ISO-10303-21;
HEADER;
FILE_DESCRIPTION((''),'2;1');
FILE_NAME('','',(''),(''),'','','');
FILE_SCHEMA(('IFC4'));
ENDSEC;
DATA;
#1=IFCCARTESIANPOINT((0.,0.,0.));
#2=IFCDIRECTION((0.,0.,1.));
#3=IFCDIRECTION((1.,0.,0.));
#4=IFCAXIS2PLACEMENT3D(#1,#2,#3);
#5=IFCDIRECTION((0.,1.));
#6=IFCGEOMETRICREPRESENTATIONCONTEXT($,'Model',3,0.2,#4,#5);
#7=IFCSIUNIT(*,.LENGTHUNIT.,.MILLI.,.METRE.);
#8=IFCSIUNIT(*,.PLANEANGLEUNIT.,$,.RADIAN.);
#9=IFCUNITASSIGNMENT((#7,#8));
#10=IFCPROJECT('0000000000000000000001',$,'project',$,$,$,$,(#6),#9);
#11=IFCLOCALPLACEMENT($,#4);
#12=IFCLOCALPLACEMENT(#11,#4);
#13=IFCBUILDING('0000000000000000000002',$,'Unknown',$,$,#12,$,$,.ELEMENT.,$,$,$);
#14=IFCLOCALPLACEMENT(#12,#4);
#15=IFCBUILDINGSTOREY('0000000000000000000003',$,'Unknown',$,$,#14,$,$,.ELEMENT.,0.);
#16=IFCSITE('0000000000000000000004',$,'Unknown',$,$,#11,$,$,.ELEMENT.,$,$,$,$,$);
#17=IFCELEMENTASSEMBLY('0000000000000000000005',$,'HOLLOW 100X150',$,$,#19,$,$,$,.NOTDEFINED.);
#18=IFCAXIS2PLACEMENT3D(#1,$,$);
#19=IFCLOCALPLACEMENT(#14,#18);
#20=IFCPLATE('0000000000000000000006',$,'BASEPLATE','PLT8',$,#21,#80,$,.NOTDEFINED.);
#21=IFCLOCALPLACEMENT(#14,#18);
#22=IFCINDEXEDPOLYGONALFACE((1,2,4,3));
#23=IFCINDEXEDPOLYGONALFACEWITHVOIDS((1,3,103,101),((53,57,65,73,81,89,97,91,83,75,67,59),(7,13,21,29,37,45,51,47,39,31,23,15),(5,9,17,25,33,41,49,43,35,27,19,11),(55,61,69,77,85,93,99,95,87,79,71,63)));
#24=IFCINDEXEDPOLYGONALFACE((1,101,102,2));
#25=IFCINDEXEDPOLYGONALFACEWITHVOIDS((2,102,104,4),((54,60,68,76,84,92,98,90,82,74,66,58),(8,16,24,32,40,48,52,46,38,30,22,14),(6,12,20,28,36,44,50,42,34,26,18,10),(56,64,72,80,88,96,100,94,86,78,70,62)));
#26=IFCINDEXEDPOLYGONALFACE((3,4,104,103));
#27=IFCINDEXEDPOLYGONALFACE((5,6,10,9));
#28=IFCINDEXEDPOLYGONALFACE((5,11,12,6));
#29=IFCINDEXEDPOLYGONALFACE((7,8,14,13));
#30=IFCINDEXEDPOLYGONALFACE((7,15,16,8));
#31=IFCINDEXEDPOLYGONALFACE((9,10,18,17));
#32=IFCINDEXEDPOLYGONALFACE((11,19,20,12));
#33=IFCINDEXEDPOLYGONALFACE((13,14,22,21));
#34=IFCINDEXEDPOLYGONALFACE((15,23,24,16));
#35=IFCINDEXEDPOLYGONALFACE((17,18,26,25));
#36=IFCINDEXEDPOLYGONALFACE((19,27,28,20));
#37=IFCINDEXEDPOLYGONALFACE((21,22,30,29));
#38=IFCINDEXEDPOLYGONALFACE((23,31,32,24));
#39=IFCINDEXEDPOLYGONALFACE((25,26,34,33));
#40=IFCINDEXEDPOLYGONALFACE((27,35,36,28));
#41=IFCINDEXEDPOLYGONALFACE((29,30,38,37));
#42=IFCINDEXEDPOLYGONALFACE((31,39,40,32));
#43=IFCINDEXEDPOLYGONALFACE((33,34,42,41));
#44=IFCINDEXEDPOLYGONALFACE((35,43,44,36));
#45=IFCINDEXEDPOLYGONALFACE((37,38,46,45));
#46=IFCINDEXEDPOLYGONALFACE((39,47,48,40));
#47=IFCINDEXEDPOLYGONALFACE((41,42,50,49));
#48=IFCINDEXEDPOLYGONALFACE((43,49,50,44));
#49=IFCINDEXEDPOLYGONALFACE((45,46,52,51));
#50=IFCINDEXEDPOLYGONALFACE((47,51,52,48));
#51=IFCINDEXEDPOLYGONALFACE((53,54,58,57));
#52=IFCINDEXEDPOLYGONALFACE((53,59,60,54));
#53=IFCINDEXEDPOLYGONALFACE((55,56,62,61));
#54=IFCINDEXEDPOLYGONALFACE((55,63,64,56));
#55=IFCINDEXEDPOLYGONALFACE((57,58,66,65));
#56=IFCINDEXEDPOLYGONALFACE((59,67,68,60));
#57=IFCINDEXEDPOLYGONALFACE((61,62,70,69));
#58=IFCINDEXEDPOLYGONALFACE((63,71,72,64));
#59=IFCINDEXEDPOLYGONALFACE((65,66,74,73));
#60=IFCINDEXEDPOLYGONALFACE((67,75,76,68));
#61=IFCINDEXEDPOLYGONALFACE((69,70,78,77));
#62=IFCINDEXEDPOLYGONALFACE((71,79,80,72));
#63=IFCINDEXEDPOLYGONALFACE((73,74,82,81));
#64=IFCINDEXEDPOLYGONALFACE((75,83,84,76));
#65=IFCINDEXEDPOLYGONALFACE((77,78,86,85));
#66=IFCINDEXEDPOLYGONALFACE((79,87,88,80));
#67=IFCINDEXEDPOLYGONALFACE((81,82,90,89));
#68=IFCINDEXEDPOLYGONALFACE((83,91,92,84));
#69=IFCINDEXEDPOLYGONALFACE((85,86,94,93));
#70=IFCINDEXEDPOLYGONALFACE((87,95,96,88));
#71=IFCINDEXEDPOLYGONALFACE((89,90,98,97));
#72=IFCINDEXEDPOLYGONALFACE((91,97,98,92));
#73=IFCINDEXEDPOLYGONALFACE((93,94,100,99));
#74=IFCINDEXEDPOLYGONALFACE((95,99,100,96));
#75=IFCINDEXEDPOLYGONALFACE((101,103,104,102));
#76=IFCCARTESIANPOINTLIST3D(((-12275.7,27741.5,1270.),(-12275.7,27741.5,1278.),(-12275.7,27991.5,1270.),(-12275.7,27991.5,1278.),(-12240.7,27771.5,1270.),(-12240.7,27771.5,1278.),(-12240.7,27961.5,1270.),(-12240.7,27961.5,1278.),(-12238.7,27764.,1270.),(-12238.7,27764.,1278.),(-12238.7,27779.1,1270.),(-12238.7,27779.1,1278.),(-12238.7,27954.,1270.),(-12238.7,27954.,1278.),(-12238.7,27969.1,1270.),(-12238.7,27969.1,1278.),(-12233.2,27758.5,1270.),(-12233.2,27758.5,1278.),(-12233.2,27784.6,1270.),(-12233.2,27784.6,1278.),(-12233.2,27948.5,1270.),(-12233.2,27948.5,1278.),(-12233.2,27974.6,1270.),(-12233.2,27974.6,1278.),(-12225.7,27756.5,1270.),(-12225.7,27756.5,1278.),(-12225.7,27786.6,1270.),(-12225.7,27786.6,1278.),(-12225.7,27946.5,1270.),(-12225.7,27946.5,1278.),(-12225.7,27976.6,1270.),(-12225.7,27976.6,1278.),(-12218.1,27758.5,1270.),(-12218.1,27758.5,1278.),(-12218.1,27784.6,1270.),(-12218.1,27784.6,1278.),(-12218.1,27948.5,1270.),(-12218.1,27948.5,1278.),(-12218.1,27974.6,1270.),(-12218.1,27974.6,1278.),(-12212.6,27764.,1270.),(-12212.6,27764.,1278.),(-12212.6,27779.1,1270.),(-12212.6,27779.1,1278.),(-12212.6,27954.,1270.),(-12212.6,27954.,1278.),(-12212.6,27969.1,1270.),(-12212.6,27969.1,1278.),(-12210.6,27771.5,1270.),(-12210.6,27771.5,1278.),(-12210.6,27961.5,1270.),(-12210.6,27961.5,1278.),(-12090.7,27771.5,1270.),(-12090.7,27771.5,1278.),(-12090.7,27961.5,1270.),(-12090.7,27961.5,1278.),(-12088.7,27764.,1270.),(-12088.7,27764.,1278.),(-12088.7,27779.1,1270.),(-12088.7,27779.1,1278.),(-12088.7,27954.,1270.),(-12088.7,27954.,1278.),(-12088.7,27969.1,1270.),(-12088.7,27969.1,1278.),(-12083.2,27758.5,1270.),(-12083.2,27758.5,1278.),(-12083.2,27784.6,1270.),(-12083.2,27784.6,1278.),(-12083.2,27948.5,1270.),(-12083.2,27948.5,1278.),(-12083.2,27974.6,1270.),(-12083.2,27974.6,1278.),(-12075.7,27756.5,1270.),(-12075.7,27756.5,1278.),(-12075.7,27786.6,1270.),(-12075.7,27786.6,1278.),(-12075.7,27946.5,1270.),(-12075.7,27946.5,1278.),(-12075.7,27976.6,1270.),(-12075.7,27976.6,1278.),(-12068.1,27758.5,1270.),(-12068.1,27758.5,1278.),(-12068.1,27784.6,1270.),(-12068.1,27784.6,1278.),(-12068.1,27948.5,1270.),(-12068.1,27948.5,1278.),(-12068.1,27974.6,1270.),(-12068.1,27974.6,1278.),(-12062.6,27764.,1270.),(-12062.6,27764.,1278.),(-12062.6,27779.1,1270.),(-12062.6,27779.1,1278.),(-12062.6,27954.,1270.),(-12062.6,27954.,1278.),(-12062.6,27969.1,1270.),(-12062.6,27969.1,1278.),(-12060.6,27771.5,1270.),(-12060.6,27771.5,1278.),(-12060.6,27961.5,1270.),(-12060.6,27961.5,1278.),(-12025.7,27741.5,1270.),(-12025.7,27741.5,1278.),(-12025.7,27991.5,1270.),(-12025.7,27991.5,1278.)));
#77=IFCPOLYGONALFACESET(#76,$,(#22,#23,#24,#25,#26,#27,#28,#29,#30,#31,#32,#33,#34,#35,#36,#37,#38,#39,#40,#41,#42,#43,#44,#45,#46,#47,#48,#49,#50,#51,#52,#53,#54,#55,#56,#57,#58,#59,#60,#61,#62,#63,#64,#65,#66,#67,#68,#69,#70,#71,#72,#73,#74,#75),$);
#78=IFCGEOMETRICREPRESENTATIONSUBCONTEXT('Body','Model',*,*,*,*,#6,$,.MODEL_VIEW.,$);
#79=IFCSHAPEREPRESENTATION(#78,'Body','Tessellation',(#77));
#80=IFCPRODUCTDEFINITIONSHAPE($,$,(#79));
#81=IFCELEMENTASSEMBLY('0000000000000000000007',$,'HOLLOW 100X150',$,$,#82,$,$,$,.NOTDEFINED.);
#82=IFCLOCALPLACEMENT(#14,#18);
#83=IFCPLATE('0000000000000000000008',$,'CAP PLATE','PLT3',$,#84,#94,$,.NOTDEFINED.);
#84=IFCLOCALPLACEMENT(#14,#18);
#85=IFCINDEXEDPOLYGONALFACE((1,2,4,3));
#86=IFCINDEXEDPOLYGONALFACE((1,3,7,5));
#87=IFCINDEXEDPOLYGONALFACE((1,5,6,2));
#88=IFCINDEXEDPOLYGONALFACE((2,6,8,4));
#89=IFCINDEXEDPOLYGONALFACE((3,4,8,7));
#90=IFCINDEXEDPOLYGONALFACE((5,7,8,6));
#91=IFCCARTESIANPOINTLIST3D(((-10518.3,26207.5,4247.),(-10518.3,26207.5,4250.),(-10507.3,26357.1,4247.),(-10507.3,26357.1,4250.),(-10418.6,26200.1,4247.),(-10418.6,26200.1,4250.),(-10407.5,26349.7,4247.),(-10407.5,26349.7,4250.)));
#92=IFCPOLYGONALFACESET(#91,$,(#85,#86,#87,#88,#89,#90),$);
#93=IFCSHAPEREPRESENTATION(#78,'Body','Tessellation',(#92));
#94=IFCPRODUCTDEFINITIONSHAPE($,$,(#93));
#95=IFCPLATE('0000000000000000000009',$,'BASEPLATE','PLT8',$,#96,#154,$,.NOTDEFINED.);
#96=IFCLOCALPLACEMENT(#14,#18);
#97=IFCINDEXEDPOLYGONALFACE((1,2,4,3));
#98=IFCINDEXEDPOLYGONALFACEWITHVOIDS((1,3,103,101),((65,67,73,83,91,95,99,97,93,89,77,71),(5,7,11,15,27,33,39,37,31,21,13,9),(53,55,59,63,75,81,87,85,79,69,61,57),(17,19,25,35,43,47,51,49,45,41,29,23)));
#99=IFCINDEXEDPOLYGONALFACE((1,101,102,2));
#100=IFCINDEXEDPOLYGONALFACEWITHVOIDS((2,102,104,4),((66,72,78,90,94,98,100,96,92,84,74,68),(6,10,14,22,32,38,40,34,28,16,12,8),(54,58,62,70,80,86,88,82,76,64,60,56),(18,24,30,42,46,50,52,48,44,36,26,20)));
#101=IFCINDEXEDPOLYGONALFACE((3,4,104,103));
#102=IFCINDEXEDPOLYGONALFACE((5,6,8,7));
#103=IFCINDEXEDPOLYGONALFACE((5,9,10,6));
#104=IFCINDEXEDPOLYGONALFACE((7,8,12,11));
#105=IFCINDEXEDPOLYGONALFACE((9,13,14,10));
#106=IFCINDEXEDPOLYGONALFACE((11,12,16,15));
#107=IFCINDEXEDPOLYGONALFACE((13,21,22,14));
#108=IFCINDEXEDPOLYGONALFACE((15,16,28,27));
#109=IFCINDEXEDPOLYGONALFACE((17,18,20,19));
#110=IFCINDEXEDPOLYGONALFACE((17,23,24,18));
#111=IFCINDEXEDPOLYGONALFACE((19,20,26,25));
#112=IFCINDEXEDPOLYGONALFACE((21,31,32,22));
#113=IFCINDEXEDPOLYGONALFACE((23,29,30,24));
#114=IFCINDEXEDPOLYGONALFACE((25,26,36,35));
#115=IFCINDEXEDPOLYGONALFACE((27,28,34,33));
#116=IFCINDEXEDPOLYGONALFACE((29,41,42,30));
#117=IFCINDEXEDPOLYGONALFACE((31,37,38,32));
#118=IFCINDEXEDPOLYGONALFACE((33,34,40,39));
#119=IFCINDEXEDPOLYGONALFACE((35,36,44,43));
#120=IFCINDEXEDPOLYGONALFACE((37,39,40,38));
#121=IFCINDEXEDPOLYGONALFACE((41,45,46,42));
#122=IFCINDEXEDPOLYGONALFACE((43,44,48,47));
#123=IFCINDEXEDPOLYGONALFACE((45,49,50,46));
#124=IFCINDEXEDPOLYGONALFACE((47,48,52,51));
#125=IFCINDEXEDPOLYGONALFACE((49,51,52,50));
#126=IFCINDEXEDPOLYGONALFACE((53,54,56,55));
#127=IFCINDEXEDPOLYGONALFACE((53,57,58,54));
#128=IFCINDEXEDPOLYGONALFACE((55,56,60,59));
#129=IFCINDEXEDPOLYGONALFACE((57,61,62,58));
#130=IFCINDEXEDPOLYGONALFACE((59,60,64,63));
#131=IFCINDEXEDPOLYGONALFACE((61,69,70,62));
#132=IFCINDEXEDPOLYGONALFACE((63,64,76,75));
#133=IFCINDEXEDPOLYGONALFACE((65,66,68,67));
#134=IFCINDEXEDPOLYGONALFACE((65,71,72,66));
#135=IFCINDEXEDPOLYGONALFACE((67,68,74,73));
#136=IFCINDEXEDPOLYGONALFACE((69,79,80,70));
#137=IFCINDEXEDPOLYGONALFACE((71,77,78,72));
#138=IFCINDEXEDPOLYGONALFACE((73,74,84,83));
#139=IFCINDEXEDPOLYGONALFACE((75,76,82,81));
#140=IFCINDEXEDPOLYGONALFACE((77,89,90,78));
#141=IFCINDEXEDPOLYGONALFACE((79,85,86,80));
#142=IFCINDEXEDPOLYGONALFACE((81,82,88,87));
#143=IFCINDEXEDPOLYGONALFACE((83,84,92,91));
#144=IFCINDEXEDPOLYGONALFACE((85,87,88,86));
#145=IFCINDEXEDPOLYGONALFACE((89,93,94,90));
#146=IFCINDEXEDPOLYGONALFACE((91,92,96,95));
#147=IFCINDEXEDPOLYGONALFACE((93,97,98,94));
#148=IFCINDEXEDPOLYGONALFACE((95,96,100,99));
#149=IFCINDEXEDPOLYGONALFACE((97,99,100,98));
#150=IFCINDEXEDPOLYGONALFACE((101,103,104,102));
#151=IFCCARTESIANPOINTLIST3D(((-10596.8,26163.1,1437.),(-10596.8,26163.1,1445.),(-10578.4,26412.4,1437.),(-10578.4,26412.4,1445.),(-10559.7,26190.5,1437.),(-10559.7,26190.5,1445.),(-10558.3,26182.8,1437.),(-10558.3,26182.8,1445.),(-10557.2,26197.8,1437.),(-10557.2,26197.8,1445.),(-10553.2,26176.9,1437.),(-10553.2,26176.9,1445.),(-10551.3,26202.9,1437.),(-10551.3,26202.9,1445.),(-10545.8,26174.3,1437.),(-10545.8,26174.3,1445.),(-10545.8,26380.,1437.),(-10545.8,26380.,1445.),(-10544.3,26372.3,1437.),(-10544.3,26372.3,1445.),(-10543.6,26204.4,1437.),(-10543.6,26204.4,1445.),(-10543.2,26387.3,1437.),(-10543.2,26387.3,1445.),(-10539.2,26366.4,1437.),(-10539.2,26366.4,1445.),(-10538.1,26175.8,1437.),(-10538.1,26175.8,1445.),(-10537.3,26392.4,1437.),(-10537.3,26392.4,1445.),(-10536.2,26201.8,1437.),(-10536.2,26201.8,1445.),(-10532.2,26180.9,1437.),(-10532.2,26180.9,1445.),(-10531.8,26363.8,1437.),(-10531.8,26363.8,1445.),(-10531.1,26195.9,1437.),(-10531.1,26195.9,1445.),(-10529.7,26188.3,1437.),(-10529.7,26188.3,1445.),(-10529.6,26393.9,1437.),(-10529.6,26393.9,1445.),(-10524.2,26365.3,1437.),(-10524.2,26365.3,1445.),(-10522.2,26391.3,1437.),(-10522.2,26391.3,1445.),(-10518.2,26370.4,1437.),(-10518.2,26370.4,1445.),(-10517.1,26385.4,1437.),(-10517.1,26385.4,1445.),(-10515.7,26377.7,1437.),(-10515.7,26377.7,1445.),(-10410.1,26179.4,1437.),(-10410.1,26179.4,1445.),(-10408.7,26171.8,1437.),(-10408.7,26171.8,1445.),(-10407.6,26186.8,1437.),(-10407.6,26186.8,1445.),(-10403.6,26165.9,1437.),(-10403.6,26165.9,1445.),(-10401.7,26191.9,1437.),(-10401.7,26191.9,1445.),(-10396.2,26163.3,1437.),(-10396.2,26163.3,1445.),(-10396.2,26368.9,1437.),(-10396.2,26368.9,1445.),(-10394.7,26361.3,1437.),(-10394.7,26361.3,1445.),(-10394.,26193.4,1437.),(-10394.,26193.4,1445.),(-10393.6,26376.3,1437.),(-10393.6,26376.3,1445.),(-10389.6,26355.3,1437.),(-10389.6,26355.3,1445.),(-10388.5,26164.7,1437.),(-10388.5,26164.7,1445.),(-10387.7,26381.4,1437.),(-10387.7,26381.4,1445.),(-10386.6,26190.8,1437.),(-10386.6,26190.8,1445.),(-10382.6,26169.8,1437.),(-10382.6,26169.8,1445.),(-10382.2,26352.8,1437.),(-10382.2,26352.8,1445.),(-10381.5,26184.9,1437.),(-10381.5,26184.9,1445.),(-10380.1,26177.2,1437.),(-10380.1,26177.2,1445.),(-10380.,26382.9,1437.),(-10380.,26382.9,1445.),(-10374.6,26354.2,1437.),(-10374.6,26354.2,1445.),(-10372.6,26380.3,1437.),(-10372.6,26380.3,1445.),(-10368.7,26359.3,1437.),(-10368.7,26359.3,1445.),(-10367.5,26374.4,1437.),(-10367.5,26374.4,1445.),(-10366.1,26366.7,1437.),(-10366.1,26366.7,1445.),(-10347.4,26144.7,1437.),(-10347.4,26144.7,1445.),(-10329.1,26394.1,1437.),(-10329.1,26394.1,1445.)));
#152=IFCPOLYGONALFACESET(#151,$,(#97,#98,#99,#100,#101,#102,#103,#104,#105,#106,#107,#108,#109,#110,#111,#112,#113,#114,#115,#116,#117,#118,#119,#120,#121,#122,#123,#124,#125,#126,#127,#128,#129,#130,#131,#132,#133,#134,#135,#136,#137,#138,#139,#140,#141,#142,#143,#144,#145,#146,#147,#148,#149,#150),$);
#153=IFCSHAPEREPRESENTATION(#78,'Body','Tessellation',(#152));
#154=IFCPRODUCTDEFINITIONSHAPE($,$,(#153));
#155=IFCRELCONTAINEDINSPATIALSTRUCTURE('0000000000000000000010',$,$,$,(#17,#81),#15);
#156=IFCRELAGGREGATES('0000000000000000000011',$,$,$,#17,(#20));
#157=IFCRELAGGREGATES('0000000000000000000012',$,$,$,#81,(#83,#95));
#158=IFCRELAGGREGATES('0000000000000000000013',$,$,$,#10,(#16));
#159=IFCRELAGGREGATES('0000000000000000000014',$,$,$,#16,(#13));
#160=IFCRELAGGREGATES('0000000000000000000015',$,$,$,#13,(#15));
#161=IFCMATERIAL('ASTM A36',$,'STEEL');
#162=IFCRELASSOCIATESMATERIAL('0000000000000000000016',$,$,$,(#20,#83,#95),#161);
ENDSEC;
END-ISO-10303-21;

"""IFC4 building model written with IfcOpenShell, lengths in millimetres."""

from ifc_helpers import new_model, si_unit, direction, frame, origin_with_axes, place, context, subcontext, project, spatial, line, indexed_curve, outline, extrude, material, element, aggregate, save


model = new_model("IFC4")

# Units and contexts
model_context = context("Model", 3, precision=0.2, world=origin_with_axes(), true_north=direction((0.0, 1.0)))
body_context = subcontext(model_context, "Body", "Model", "MODEL_VIEW")
ifc_project = project(units=[si_unit("LENGTHUNIT", "METRE", prefix="MILLI"), si_unit("PLANEANGLEUNIT", "RADIAN")], contexts=[model_context])

# Site, building, storey
site_placement = place(None, origin_with_axes())
site = spatial("IfcSite", under=ifc_project, at=site_placement, Name="Unknown", CompositionType="ELEMENT")
building_placement = place(site_placement, origin_with_axes())
building = spatial("IfcBuilding", under=site, at=building_placement, Name="Unknown", CompositionType="ELEMENT")
storey_placement = place(building_placement, origin_with_axes())
storey = spatial("IfcBuildingStorey", under=building, at=storey_placement, Name="Unknown", CompositionType="ELEMENT", Elevation=0.0)

# Shared definitions
ifc_material_1 = material(Name="ASTM A36", Category="STEEL")

# Element assembly, plate, voiding features
assembly_1_placement = place(storey_placement, frame((-12150.7, 27866.5, 1179.9), z_axis=(-0.073569, -0.99729, 0.0), x_axis=(0.0, 0.0, 1.0)))
assembly_1 = element("IfcElementAssembly", 1, at=assembly_1_placement, inside=storey, Name="HOLLOW 100X150", PredefinedType="NOTDEFINED")
plate_1_placement = place(assembly_1_placement, frame((94.1, 133.9, -115.5), z_axis=(-1.0, 0.0, 0.0), x_axis=(0.0, -0.99729, -0.073569)))
plate_1 = element("IfcPlate", 2, at=plate_1_placement, material=ifc_material_1, Name="BASEPLATE", Description="PLT8", PredefinedType="NOTDEFINED", context=body_context, shape_type="SolidModel", body=[
    extrude(outline(indexed_curve([(0.0, 0.0), (250.0, 0.0), (250.0, 250.0), (0.0, 250.0)], segments=[line(1, 2, 3, 4, 1)])), frame((0.0, 0.0, 4.0), z_axis=(0.0, 0.0, 1.0), x_axis=(1.0, 0.0, 0.0)), (0.0, 0.0, -1.0), 8.0),
])
voiding_feature_1_placement = place(plate_1_placement, frame((200.0, 30.0, 4.5), z_axis=(-1.0, 0.0, 0.0), x_axis=(0.0, 0.0, -1.0)))
element("IfcVoidingFeature", 3, at=voiding_feature_1_placement, cuts=plate_1, Name="BEAM", PredefinedType="HOLE", context=body_context, shape_type="SolidModel", body=[
    extrude(outline(indexed_curve([(15.1, 0.0), (13.1, 7.5), (7.5, 13.1), (0.0, 15.1), (-7.5, 13.1), (-13.1, 7.5), (-15.1, 0.0), (-13.1, -7.5), (-7.5, -13.1), (0.0, -15.1), (7.5, -13.1), (13.1, -7.5)], segments=[line(1, 2, 3, 4, 5, 6, 7, 8, 9, 10, 11, 12, 1)])), frame((0.0, 0.0, 0.0), z_axis=(-1.0, 0.0, 0.0), x_axis=(0.0, 0.0, 1.0)), (0.0, 0.0, -1.0), 9.0),
])
voiding_feature_2_placement = place(plate_1_placement, frame((50.0, 30.0, 4.5), z_axis=(-1.0, 0.0, 0.0), x_axis=(0.0, 0.0, -1.0)))
element("IfcVoidingFeature", 4, at=voiding_feature_2_placement, cuts=plate_1, Name="BEAM", PredefinedType="HOLE", context=body_context, shape_type="SolidModel", body=[
    extrude(outline(indexed_curve([(15.1, 0.0), (13.1, 7.5), (7.5, 13.1), (0.0, 15.1), (-7.5, 13.1), (-13.1, 7.5), (-15.1, 0.0), (-13.1, -7.5), (-7.5, -13.1), (0.0, -15.1), (7.5, -13.1), (13.1, -7.5)], segments=[line(1, 2, 3, 4, 5, 6, 7, 8, 9, 10, 11, 12, 1)])), frame((0.0, 0.0, 0.0), z_axis=(-1.0, 0.0, 0.0), x_axis=(0.0, 0.0, 1.0)), (0.0, 0.0, -1.0), 9.0),
])
voiding_feature_3_placement = place(plate_1_placement, frame((200.0, 220.0, 4.5), z_axis=(-1.0, 0.0, 0.0), x_axis=(0.0, 0.0, -1.0)))
element("IfcVoidingFeature", 5, at=voiding_feature_3_placement, cuts=plate_1, Name="BEAM", PredefinedType="HOLE", context=body_context, shape_type="SolidModel", body=[
    extrude(outline(indexed_curve([(15.1, 0.0), (13.1, 7.5), (7.5, 13.1), (0.0, 15.1), (-7.5, 13.1), (-13.1, 7.5), (-15.1, 0.0), (-13.1, -7.5), (-7.5, -13.1), (0.0, -15.1), (7.5, -13.1), (13.1, -7.5)], segments=[line(1, 2, 3, 4, 5, 6, 7, 8, 9, 10, 11, 12, 1)])), frame((0.0, 0.0, 0.0), z_axis=(-1.0, 0.0, 0.0), x_axis=(0.0, 0.0, 1.0)), (0.0, 0.0, -1.0), 9.0),
])
voiding_feature_4_placement = place(plate_1_placement, frame((50.0, 220.0, 4.5), z_axis=(-1.0, 0.0, 0.0), x_axis=(0.0, 0.0, -1.0)))
element("IfcVoidingFeature", 6, at=voiding_feature_4_placement, cuts=plate_1, Name="BEAM", PredefinedType="HOLE", context=body_context, shape_type="SolidModel", body=[
    extrude(outline(indexed_curve([(15.1, 0.0), (13.1, 7.5), (7.5, 13.1), (0.0, 15.1), (-7.5, 13.1), (-13.1, 7.5), (-15.1, 0.0), (-13.1, -7.5), (-7.5, -13.1), (0.0, -15.1), (7.5, -13.1), (13.1, -7.5)], segments=[line(1, 2, 3, 4, 5, 6, 7, 8, 9, 10, 11, 12, 1)])), frame((0.0, 0.0, 0.0), z_axis=(-1.0, 0.0, 0.0), x_axis=(0.0, 0.0, 1.0)), (0.0, 0.0, -1.0), 9.0),
])
aggregate(assembly_1, [plate_1])

# Element assembly, plates, voiding features
assembly_2_placement = place(storey_placement, frame((-10462.9, 26278.6, 1346.9), z_axis=(-0.073569, -0.99729, 0.0), x_axis=(0.0, 0.0, 1.0)))
assembly_2 = element("IfcElementAssembly", 7, at=assembly_2_placement, inside=storey, Name="HOLLOW 100X150", PredefinedType="NOTDEFINED")
plate_2_placement = place(assembly_2_placement, frame((2901.6, 50.0, 75.0), z_axis=(1.0, 0.0, 0.0), x_axis=(0.0, -1.0, 0.0)))
plate_2 = element("IfcPlate", 8, at=plate_2_placement, material=ifc_material_1, Name="CAP PLATE", Description="PLT3", PredefinedType="NOTDEFINED", context=body_context, shape_type="SolidModel", body=[
    extrude(outline(indexed_curve([(0.0, 0.0), (100.0, 0.0), (100.0, 150.0), (0.0, 150.0)], segments=[line(1, 2, 3, 4, 1)])), frame((0.0, 0.0, 1.5), z_axis=(0.0, 0.0, 1.0), x_axis=(1.0, 0.0, 0.0)), (0.0, 0.0, -1.0), 3.0),
])
plate_3_placement = place(assembly_2_placement, frame((94.1, 125.0, -125.0), z_axis=(-1.0, 0.0, 0.0), x_axis=(0.0, -1.0, 0.0)))
plate_3 = element("IfcPlate", 9, at=plate_3_placement, material=ifc_material_1, Name="BASEPLATE", Description="PLT8", PredefinedType="NOTDEFINED", context=body_context, shape_type="SolidModel", body=[
    extrude(outline(indexed_curve([(0.0, 0.0), (250.0, 0.0), (250.0, 250.0), (0.0, 250.0)], segments=[line(1, 2, 3, 4, 1)])), frame((0.0, 0.0, 4.0), z_axis=(0.0, 0.0, 1.0), x_axis=(1.0, 0.0, 0.0)), (0.0, 0.0, -1.0), 8.0),
])
voiding_feature_5_placement = place(plate_3_placement, frame((200.0, 30.0, 4.5), z_axis=(-1.0, 0.0, 0.0), x_axis=(0.0, 0.0, -1.0)))
element("IfcVoidingFeature", 10, at=voiding_feature_5_placement, cuts=plate_3, Name="BEAM", PredefinedType="HOLE", context=body_context, shape_type="SolidModel", body=[
    extrude(outline(indexed_curve([(15.1, 0.0), (13.1, 7.5), (7.5, 13.1), (0.0, 15.1), (-7.5, 13.1), (-13.1, 7.5), (-15.1, 0.0), (-13.1, -7.5), (-7.5, -13.1), (0.0, -15.1), (7.5, -13.1), (13.1, -7.5)], segments=[line(1, 2, 3, 4, 5, 6, 7, 8, 9, 10, 11, 12, 1)])), frame((0.0, 0.0, 0.0), z_axis=(-1.0, 0.0, 0.0), x_axis=(0.0, 0.0, 1.0)), (0.0, 0.0, -1.0), 9.0),
])
voiding_feature_6_placement = place(plate_3_placement, frame((50.0, 30.0, 4.5), z_axis=(-1.0, 0.0, 0.0), x_axis=(0.0, 0.0, -1.0)))
element("IfcVoidingFeature", 11, at=voiding_feature_6_placement, cuts=plate_3, Name="BEAM", PredefinedType="HOLE", context=body_context, shape_type="SolidModel", body=[
    extrude(outline(indexed_curve([(15.1, 0.0), (13.1, 7.5), (7.5, 13.1), (0.0, 15.1), (-7.5, 13.1), (-13.1, 7.5), (-15.1, 0.0), (-13.1, -7.5), (-7.5, -13.1), (0.0, -15.1), (7.5, -13.1), (13.1, -7.5)], segments=[line(1, 2, 3, 4, 5, 6, 7, 8, 9, 10, 11, 12, 1)])), frame((0.0, 0.0, 0.0), z_axis=(-1.0, 0.0, 0.0), x_axis=(0.0, 0.0, 1.0)), (0.0, 0.0, -1.0), 9.0),
])
voiding_feature_7_placement = place(plate_3_placement, frame((200.0, 220.0, 4.5), z_axis=(-1.0, 0.0, 0.0), x_axis=(0.0, 0.0, -1.0)))
element("IfcVoidingFeature", 12, at=voiding_feature_7_placement, cuts=plate_3, Name="BEAM", PredefinedType="HOLE", context=body_context, shape_type="SolidModel", body=[
    extrude(outline(indexed_curve([(15.1, 0.0), (13.1, 7.5), (7.5, 13.1), (0.0, 15.1), (-7.5, 13.1), (-13.1, 7.5), (-15.1, 0.0), (-13.1, -7.5), (-7.5, -13.1), (0.0, -15.1), (7.5, -13.1), (13.1, -7.5)], segments=[line(1, 2, 3, 4, 5, 6, 7, 8, 9, 10, 11, 12, 1)])), frame((0.0, 0.0, 0.0), z_axis=(-1.0, 0.0, 0.0), x_axis=(0.0, 0.0, 1.0)), (0.0, 0.0, -1.0), 9.0),
])
voiding_feature_8_placement = place(plate_3_placement, frame((50.0, 220.0, 4.5), z_axis=(-1.0, 0.0, 0.0), x_axis=(0.0, 0.0, -1.0)))
element("IfcVoidingFeature", 13, at=voiding_feature_8_placement, cuts=plate_3, Name="BEAM", PredefinedType="HOLE", context=body_context, shape_type="SolidModel", body=[
    extrude(outline(indexed_curve([(15.1, 0.0), (13.1, 7.5), (7.5, 13.1), (0.0, 15.1), (-7.5, 13.1), (-13.1, 7.5), (-15.1, 0.0), (-13.1, -7.5), (-7.5, -13.1), (0.0, -15.1), (7.5, -13.1), (13.1, -7.5)], segments=[line(1, 2, 3, 4, 5, 6, 7, 8, 9, 10, 11, 12, 1)])), frame((0.0, 0.0, 0.0), z_axis=(-1.0, 0.0, 0.0), x_axis=(0.0, 0.0, 1.0)), (0.0, 0.0, -1.0), 9.0),
])
aggregate(assembly_2, [plate_2, plate_3])

save(model, "model.ifc")
